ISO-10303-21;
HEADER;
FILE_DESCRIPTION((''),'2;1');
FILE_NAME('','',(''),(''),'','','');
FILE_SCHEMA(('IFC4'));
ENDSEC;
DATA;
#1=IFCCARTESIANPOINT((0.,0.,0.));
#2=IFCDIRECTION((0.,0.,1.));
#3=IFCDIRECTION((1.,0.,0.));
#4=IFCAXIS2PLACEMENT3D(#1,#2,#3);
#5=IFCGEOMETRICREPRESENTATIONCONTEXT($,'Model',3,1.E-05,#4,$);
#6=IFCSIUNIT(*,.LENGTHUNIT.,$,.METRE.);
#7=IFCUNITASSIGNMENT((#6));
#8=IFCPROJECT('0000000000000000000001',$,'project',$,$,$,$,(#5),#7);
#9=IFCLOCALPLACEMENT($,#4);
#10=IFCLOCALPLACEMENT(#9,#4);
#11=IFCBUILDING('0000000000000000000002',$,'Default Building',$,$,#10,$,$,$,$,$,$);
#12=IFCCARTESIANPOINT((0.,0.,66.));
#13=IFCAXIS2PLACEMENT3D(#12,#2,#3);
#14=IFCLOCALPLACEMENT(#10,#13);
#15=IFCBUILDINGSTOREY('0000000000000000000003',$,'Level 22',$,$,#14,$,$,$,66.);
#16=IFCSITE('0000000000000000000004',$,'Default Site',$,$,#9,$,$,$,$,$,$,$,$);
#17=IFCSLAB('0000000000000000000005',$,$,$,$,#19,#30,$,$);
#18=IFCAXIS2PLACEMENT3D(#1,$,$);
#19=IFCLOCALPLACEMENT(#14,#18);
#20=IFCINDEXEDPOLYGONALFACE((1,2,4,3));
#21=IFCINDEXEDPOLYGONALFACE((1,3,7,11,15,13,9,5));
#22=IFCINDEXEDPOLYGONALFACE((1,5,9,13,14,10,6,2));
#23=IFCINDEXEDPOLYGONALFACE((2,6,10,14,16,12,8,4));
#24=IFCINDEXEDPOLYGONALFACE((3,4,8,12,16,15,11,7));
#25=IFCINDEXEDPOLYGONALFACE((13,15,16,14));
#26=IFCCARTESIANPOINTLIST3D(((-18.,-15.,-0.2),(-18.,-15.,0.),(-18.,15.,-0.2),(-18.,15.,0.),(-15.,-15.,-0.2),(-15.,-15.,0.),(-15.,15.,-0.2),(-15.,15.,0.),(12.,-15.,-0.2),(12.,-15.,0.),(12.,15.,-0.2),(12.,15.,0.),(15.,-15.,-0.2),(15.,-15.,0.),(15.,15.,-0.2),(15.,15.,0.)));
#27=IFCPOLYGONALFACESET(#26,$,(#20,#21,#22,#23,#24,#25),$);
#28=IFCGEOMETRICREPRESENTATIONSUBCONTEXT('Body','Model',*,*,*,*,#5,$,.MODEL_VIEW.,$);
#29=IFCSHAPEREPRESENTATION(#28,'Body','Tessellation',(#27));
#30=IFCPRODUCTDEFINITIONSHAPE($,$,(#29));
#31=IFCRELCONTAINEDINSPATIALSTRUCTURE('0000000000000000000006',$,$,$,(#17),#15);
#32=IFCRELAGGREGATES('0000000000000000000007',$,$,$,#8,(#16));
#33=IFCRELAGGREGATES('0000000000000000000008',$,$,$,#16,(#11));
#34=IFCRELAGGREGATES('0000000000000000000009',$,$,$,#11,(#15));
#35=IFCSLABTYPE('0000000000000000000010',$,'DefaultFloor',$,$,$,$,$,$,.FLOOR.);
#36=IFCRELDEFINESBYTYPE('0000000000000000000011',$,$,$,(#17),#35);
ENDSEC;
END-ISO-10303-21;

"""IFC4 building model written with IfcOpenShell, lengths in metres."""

from ifc_helpers import new_model, si_unit, frame, origin_with_axes, place, context, subcontext, project, spatial, polyline, outline, extrude, type_object, element, save


model = new_model("IFC4")

# Units and contexts
model_context = context("Model", 3, precision=1e-05, world=origin_with_axes())
body_context = subcontext(model_context, "Body", "Model", "MODEL_VIEW")
ifc_project = project(units=[si_unit("LENGTHUNIT", "METRE")], contexts=[model_context])

# Site, building, storey
site_placement = place(None, origin_with_axes())
site = spatial("IfcSite", under=ifc_project, at=site_placement, Name="Default Site")
building_placement = place(site_placement, origin_with_axes())
building = spatial("IfcBuilding", under=site, at=building_placement, Name="Default Building")
storey_placement = place(building_placement, frame((0.0, 0.0, 66.0), z_axis=(0.0, 0.0, 1.0), x_axis=(1.0, 0.0, 0.0)))
storey = spatial("IfcBuildingStorey", under=building, at=storey_placement, Name="Level 22", Elevation=66.0)

# Slab
slab_type = type_object("IfcSlabType", Name="DefaultFloor", PredefinedType="FLOOR")
slab_placement = place(storey_placement, frame((0.0, 0.0, -66.0), z_axis=(0.0, 0.0, 1.0), x_axis=(1.0, 0.0, 0.0)))
element("IfcSlab", 1, at=slab_placement, inside=storey, type_object=slab_type, context=body_context, shape_type="SweptSolid", body=[
    extrude(outline(polyline([(-18.0, -15.0), (-18.0, 15.0), (-15.0, 15.0), (12.0, 15.0), (15.0, 15.0), (15.0, -15.0), (12.0, -15.0), (-15.0, -15.0), (-18.0, -15.0)])), frame((0.0, 0.0, 66.0), z_axis=(0.0, 0.0, 1.0), x_axis=(1.0, 0.0, 0.0)), (0.0, 0.0, -1.0), 0.2),
])

save(model, "model.ifc")
